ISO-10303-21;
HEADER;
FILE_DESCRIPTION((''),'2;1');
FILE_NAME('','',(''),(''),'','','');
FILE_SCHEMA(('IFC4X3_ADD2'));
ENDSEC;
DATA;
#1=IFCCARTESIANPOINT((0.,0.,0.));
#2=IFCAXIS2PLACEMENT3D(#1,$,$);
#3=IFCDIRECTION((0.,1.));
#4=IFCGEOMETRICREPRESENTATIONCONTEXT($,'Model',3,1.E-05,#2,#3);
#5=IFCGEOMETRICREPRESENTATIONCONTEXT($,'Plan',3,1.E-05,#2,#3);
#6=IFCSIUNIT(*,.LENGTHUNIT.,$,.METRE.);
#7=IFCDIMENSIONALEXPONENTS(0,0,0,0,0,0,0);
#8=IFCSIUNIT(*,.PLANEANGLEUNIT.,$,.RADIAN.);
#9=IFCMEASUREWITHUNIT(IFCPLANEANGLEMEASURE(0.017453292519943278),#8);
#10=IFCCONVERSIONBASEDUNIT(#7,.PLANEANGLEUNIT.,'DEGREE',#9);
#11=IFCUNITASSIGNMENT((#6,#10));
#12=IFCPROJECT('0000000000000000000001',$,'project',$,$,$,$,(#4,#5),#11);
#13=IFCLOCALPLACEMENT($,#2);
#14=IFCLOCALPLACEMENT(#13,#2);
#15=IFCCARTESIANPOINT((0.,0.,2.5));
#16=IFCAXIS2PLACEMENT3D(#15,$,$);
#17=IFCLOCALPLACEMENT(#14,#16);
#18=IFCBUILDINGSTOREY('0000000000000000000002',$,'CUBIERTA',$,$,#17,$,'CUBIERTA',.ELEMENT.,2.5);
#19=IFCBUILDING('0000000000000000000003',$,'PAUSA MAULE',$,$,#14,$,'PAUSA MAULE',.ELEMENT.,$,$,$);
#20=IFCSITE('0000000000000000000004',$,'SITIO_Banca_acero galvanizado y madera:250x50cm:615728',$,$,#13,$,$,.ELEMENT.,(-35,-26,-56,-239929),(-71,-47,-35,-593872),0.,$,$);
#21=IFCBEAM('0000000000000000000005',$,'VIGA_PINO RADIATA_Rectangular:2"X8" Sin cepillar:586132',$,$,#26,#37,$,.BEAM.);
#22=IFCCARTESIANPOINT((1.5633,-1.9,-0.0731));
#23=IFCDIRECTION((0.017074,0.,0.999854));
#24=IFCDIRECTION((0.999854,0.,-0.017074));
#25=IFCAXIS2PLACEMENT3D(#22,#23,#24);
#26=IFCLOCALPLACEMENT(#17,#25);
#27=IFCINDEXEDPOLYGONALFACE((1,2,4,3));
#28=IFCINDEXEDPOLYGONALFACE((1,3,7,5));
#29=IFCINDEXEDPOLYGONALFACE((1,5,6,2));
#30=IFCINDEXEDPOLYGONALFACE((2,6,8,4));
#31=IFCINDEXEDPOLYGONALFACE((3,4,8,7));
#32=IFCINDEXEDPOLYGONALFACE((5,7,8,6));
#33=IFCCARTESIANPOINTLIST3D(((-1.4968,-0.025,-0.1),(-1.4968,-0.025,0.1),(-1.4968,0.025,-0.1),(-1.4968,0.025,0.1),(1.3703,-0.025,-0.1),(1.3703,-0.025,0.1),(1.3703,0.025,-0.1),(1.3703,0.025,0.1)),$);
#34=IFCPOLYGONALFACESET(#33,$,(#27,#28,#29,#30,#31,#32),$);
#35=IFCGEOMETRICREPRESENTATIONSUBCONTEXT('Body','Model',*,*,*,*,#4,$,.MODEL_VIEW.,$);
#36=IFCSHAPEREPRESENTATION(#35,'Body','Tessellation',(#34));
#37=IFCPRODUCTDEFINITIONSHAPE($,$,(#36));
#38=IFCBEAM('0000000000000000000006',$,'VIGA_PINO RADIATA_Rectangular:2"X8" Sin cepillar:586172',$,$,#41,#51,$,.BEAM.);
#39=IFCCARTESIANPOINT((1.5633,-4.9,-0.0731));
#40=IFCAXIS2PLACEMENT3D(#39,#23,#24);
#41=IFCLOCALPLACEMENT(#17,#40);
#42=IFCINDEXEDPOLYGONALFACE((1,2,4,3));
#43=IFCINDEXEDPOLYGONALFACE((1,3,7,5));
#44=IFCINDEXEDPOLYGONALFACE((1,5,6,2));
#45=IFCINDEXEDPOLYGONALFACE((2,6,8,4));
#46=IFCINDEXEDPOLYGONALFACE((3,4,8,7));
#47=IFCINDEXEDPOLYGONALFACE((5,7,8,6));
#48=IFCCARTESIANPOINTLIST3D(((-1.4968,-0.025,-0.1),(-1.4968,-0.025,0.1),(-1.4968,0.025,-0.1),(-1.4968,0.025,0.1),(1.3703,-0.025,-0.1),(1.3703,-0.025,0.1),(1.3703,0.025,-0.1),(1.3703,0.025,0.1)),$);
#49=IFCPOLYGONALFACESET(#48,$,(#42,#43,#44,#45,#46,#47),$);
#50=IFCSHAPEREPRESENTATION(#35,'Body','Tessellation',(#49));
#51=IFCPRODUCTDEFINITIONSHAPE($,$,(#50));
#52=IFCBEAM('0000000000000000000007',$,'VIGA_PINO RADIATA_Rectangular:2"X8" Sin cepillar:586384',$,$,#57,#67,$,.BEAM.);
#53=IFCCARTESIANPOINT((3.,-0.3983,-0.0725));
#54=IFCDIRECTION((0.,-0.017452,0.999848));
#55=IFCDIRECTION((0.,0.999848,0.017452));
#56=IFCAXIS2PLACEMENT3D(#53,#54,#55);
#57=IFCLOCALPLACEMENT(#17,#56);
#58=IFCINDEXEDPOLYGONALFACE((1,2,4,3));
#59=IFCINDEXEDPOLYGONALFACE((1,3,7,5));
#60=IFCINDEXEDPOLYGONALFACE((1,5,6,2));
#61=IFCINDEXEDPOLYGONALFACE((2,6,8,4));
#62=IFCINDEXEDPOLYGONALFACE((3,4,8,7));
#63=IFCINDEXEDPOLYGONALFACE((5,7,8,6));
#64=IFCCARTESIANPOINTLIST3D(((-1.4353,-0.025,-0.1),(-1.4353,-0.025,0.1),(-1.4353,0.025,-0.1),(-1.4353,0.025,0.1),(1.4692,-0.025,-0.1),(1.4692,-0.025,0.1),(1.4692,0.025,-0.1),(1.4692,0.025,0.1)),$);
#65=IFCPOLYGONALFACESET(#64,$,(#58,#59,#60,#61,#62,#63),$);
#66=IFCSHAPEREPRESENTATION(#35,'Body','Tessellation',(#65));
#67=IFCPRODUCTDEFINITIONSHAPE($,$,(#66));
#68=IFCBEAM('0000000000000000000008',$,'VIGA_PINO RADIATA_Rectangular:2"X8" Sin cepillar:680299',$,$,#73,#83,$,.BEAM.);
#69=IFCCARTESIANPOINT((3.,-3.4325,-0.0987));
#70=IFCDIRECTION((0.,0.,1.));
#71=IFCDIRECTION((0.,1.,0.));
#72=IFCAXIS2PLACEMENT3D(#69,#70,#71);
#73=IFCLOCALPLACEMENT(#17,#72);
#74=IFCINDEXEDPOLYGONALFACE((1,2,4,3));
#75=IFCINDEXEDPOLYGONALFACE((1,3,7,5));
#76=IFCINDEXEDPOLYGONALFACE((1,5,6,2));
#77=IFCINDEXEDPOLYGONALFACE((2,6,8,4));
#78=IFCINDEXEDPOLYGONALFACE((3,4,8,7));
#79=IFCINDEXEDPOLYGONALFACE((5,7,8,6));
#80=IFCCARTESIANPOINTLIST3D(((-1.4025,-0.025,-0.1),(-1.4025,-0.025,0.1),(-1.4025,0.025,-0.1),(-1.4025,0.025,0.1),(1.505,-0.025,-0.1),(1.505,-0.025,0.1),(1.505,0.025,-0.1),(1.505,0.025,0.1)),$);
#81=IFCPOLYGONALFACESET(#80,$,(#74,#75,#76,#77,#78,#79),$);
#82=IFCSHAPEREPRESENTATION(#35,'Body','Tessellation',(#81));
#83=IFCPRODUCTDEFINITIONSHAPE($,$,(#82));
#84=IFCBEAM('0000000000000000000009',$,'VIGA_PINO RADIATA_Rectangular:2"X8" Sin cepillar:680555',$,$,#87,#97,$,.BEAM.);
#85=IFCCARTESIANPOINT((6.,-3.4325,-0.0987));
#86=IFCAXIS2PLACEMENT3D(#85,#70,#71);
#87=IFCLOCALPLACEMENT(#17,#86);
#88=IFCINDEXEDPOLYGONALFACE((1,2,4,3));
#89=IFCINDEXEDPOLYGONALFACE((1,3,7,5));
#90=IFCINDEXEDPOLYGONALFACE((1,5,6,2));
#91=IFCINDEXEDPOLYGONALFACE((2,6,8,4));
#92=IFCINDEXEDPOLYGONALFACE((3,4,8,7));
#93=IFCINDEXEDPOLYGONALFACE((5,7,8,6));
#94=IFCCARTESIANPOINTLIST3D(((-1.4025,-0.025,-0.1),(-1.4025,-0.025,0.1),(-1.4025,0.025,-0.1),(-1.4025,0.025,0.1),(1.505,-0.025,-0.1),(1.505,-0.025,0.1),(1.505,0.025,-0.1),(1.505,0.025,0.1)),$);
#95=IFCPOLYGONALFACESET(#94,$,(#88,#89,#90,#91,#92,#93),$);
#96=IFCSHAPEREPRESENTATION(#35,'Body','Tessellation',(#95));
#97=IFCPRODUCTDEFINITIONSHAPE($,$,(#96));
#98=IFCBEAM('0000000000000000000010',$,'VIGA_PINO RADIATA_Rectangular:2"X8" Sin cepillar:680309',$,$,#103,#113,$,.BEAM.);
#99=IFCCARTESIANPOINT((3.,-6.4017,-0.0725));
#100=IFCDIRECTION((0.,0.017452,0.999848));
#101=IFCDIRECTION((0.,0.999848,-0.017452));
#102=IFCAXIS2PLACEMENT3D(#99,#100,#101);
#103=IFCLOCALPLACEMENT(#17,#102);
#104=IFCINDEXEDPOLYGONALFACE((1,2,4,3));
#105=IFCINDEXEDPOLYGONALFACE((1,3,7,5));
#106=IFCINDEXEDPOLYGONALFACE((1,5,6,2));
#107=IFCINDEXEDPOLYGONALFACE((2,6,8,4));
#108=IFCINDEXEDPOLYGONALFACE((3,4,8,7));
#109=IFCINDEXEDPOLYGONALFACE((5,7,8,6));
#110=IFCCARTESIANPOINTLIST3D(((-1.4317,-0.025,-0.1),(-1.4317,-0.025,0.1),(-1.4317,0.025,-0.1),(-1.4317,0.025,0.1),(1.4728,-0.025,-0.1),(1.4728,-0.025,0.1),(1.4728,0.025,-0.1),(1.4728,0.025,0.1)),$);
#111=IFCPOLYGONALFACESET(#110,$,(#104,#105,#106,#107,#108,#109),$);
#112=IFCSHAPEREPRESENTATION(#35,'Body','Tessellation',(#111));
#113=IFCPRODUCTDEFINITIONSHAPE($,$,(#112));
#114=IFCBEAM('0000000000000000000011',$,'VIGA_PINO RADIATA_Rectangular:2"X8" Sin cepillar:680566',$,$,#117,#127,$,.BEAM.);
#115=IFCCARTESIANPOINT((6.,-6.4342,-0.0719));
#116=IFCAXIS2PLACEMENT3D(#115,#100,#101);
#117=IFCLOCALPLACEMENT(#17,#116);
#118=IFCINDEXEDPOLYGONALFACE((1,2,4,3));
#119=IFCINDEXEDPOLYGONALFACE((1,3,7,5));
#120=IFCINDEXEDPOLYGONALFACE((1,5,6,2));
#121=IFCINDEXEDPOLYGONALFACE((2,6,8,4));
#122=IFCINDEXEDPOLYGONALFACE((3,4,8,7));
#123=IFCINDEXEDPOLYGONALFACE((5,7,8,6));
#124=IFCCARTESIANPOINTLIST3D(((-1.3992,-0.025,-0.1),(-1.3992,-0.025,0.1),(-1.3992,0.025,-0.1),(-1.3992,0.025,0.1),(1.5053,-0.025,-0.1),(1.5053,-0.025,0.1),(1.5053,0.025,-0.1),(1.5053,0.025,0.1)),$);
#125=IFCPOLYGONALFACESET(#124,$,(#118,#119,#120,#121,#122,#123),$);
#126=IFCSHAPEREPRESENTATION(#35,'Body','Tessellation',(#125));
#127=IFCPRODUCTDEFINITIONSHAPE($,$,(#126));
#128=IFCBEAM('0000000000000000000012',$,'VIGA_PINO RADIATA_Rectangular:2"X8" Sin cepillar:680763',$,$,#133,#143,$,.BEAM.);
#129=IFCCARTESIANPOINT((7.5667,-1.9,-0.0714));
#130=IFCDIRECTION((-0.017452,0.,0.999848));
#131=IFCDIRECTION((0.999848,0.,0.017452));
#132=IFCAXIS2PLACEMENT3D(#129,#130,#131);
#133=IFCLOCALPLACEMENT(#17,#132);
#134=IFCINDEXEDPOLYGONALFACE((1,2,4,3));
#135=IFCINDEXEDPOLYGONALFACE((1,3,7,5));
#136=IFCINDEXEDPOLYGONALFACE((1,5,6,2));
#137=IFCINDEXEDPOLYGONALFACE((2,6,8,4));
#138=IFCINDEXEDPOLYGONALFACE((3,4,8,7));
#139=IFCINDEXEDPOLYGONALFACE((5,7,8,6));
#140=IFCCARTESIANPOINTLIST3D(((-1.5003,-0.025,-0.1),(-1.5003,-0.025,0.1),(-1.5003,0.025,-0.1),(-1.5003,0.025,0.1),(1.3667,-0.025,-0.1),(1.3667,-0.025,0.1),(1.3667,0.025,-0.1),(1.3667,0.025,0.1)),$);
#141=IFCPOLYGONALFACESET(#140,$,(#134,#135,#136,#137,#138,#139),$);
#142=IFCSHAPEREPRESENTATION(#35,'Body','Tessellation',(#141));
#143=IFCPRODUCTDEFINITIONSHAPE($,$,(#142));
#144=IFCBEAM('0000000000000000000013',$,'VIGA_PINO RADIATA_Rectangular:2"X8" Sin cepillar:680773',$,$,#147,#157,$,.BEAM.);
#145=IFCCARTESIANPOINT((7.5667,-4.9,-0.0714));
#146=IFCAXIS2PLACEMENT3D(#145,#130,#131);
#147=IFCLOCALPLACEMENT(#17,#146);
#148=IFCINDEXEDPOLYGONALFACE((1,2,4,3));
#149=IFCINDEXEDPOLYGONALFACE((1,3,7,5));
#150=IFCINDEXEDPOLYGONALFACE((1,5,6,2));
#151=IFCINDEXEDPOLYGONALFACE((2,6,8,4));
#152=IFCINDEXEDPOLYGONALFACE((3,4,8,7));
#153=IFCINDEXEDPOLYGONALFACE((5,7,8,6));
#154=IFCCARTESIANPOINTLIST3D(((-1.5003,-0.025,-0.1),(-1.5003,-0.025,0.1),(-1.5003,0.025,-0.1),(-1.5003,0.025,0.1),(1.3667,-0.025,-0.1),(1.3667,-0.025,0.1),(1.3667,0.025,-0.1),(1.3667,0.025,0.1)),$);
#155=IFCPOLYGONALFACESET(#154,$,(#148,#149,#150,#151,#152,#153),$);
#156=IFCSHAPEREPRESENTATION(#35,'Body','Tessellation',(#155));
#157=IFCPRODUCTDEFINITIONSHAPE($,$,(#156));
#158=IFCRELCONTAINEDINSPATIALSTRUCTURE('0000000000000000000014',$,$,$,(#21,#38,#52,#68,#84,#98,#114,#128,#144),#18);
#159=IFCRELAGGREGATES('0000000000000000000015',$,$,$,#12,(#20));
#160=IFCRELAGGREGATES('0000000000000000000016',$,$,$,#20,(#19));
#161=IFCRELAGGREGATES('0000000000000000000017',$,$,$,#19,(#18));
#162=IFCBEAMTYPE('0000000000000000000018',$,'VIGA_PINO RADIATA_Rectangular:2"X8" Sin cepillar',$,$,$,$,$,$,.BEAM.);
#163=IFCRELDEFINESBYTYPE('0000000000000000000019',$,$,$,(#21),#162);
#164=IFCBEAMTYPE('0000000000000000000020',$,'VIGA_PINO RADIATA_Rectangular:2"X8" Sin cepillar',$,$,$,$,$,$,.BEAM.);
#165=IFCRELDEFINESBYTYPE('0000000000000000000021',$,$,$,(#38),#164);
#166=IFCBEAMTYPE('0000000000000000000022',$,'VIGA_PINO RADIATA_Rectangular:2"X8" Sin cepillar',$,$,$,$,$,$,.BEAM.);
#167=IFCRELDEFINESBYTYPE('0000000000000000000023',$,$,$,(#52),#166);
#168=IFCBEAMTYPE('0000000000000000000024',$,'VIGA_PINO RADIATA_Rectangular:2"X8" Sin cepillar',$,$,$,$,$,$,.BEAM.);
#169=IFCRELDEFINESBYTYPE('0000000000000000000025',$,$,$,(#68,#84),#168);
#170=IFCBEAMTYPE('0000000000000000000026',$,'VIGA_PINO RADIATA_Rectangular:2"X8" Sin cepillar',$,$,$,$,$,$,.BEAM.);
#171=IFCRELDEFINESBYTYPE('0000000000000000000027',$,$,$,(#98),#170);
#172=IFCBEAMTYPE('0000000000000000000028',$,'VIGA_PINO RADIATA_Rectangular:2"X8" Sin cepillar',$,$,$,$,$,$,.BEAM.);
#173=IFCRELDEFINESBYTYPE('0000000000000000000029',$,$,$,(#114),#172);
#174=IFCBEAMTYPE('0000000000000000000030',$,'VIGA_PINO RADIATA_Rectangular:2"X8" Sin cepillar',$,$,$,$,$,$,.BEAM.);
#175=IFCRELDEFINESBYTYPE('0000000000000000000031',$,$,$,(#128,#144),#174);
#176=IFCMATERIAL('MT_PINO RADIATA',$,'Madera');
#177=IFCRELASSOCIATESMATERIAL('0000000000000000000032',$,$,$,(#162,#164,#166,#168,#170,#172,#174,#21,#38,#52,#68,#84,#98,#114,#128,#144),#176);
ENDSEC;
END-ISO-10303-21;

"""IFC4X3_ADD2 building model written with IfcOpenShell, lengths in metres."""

from ifc_helpers import new_model, entity, si_unit, converted_unit, direction, frame, origin, origin_2d_with_axis, place, context, subcontext, project, spatial, rectangle, extrude, source, transform, mapped, material, material_profile, profile_set, profile_usage, type_object, type_shapes, element, save


model = new_model("IFC4X3_ADD2")

# Units and contexts
model_context = context("Model", 3, precision=1e-05, world=origin(), true_north=direction((0.0, 1.0)))
plan_context = context("Plan", 3, precision=1e-05, world=origin(), true_north=direction((0.0, 1.0)))
body_context = subcontext(model_context, "Body", "Model", "MODEL_VIEW")
ifc_project = project(units=[si_unit("LENGTHUNIT", "METRE"), converted_unit("PLANEANGLEUNIT", "DEGREE", entity("IfcPlaneAngleMeasure", 0.017453292519943278), si_unit("PLANEANGLEUNIT", "RADIAN"), dimensions=[0, 0, 0, 0, 0, 0, 0])], contexts=[model_context, plan_context])

# Site, building, storey
site_placement = place(None, origin())
site = spatial("IfcSite", under=ifc_project, at=site_placement, Name="SITIO_Banca_acero galvanizado y madera:250x50cm:615728", CompositionType="ELEMENT", RefLatitude=(-35, -26, -56, -239929), RefLongitude=(-71, -47, -35, -593872), RefElevation=0.0)
building_placement = place(site_placement, origin())
building = spatial("IfcBuilding", under=site, at=building_placement, Name="PAUSA MAULE", LongName="PAUSA MAULE", CompositionType="ELEMENT")
storey_placement = place(building_placement, frame((0.0, 0.0, 2.5)))
storey = spatial("IfcBuildingStorey", under=building, at=storey_placement, Name="CUBIERTA", LongName="CUBIERTA", CompositionType="ELEMENT", Elevation=2.5)

# Beams
ifc_material_1 = material(Name="MT_PINO RADIATA", Category="Madera")
ifc_material_profile_1 = material_profile(ifc_material_1, rectangle(XDim=8.87, YDim=0.05, at=origin_2d_with_axis()), Name="2\"X8\" Sin cepillar")
ifc_profile_set_1 = profile_set([ifc_material_profile_1], Name="2\"X8\" Sin cepillar")
ifc_profile_usage_1 = profile_usage(ifc_profile_set_1, cardinal=8)
beam_type_1 = type_object("IfcBeamType", Name="VIGA_PINO RADIATA_Rectangular:2\"X8\" Sin cepillar", PredefinedType="BEAM", material=ifc_profile_set_1)
shared_shape_1 = source(origin(), body_context, "Body", "SweptSolid", [
    extrude(rectangle(XDim=2.8671, YDim=0.05, at=origin_2d_with_axis()), frame((-0.0633, 0.0, -0.1), z_axis=(0.0, 0.0, 1.0), x_axis=(-1.0, 0.0, 0.0)), (0.0, 0.0, 1.0), 0.2),
])
type_shapes(beam_type_1, [shared_shape_1])
beam_1_placement = place(storey_placement, frame((1.5633, -1.9, -0.0731), z_axis=(0.017074, 0.0, 0.999854), x_axis=(0.999854, 0.0, -0.017074)))
element("IfcBeam", 1, at=beam_1_placement, inside=storey, type_object=beam_type_1, material=ifc_profile_usage_1, Name="VIGA_PINO RADIATA_Rectangular:2\"X8\" Sin cepillar:586132", PredefinedType="BEAM", context=body_context, shape_type="MappedRepresentation", body=[
    mapped(shared_shape_1, transform((0.0, 0.0, 0.0), scale=1.0)),
])
beam_type_2 = type_object("IfcBeamType", Name="VIGA_PINO RADIATA_Rectangular:2\"X8\" Sin cepillar", PredefinedType="BEAM", material=ifc_profile_set_1)
shared_shape_2 = source(origin(), body_context, "Body", "SweptSolid", [
    extrude(rectangle(XDim=2.8671, YDim=0.05, at=origin_2d_with_axis()), frame((-0.0633, 0.0, -0.1), z_axis=(0.0, 0.0, 1.0), x_axis=(-1.0, 0.0, 0.0)), (0.0, 0.0, 1.0), 0.2),
])
type_shapes(beam_type_2, [shared_shape_2])
beam_2_placement = place(storey_placement, frame((1.5633, -4.9, -0.0731), z_axis=(0.017074, 0.0, 0.999854), x_axis=(0.999854, 0.0, -0.017074)))
element("IfcBeam", 2, at=beam_2_placement, inside=storey, type_object=beam_type_2, material=ifc_profile_usage_1, Name="VIGA_PINO RADIATA_Rectangular:2\"X8\" Sin cepillar:586172", PredefinedType="BEAM", context=body_context, shape_type="MappedRepresentation", body=[
    mapped(shared_shape_2, transform((0.0, 0.0, 0.0), scale=1.0)),
])
beam_type_3 = type_object("IfcBeamType", Name="VIGA_PINO RADIATA_Rectangular:2\"X8\" Sin cepillar", PredefinedType="BEAM", material=ifc_profile_set_1)
shared_shape_3 = source(origin(), body_context, "Body", "SweptSolid", [
    extrude(rectangle(XDim=2.9045, YDim=0.05, at=origin_2d_with_axis()), frame((0.017, 0.0, -0.1), z_axis=(0.0, 0.0, 1.0), x_axis=(-1.0, 0.0, 0.0)), (0.0, 0.0, 1.0), 0.2),
])
type_shapes(beam_type_3, [shared_shape_3])
beam_3_placement = place(storey_placement, frame((3.0, -0.3983, -0.0725), z_axis=(0.0, -0.017452, 0.999848), x_axis=(0.0, 0.999848, 0.017452)))
element("IfcBeam", 3, at=beam_3_placement, inside=storey, type_object=beam_type_3, material=ifc_profile_usage_1, Name="VIGA_PINO RADIATA_Rectangular:2\"X8\" Sin cepillar:586384", PredefinedType="BEAM", context=body_context, shape_type="MappedRepresentation", body=[
    mapped(shared_shape_3, transform((0.0, 0.0, 0.0), scale=1.0)),
])

# Beams
beam_type_4 = type_object("IfcBeamType", Name="VIGA_PINO RADIATA_Rectangular:2\"X8\" Sin cepillar", PredefinedType="BEAM", material=ifc_profile_set_1)
shared_shape_4 = source(origin(), body_context, "Body", "SweptSolid", [
    extrude(rectangle(XDim=2.9075, YDim=0.05, at=origin_2d_with_axis()), frame((0.0512, 0.0, -0.1), z_axis=(0.0, 0.0, 1.0), x_axis=(-1.0, 0.0, 0.0)), (0.0, 0.0, 1.0), 0.2),
])
type_shapes(beam_type_4, [shared_shape_4])
for number, where, z_axis, x_axis, name in (
    (4, (3.0, -3.4325, -0.0987), (0.0, 0.0, 1.0), (0.0, 1.0, 0.0), "VIGA_PINO RADIATA_Rectangular:2\"X8\" Sin cepillar:680299"),
    (5, (6.0, -3.4325, -0.0987), (0.0, 0.0, 1.0), (0.0, 1.0, 0.0), "VIGA_PINO RADIATA_Rectangular:2\"X8\" Sin cepillar:680555"),
):
    element("IfcBeam", number, at=place(storey_placement, frame(where, z_axis=z_axis, x_axis=x_axis)), inside=storey, type_object=beam_type_4, material=ifc_profile_usage_1, Name=name, PredefinedType="BEAM", context=body_context, shape_type="MappedRepresentation", body=[
        mapped(shared_shape_4, transform((0.0, 0.0, 0.0), scale=1.0)),
    ])
beam_type_5 = type_object("IfcBeamType", Name="VIGA_PINO RADIATA_Rectangular:2\"X8\" Sin cepillar", PredefinedType="BEAM", material=ifc_profile_set_1)
shared_shape_5 = source(origin(), body_context, "Body", "SweptSolid", [
    extrude(rectangle(XDim=2.9045, YDim=0.05, at=origin_2d_with_axis()), frame((0.0205, 0.0, -0.1), z_axis=(0.0, 0.0, 1.0), x_axis=(-1.0, 0.0, 0.0)), (0.0, 0.0, 1.0), 0.2),
])
type_shapes(beam_type_5, [shared_shape_5])
beam_4_placement = place(storey_placement, frame((3.0, -6.4017, -0.0725), z_axis=(0.0, 0.017452, 0.999848), x_axis=(0.0, 0.999848, -0.017452)))
element("IfcBeam", 6, at=beam_4_placement, inside=storey, type_object=beam_type_5, material=ifc_profile_usage_1, Name="VIGA_PINO RADIATA_Rectangular:2\"X8\" Sin cepillar:680309", PredefinedType="BEAM", context=body_context, shape_type="MappedRepresentation", body=[
    mapped(shared_shape_5, transform((0.0, 0.0, 0.0), scale=1.0)),
])
beam_type_6 = type_object("IfcBeamType", Name="VIGA_PINO RADIATA_Rectangular:2\"X8\" Sin cepillar", PredefinedType="BEAM", material=ifc_profile_set_1)
shared_shape_6 = source(origin(), body_context, "Body", "SweptSolid", [
    extrude(rectangle(XDim=2.9045, YDim=0.05, at=origin_2d_with_axis()), frame((0.053, 0.0, -0.1), z_axis=(0.0, 0.0, 1.0), x_axis=(-1.0, 0.0, 0.0)), (0.0, 0.0, 1.0), 0.2),
])
type_shapes(beam_type_6, [shared_shape_6])
beam_5_placement = place(storey_placement, frame((6.0, -6.4342, -0.0719), z_axis=(0.0, 0.017452, 0.999848), x_axis=(0.0, 0.999848, -0.017452)))
element("IfcBeam", 7, at=beam_5_placement, inside=storey, type_object=beam_type_6, material=ifc_profile_usage_1, Name="VIGA_PINO RADIATA_Rectangular:2\"X8\" Sin cepillar:680566", PredefinedType="BEAM", context=body_context, shape_type="MappedRepresentation", body=[
    mapped(shared_shape_6, transform((0.0, 0.0, 0.0), scale=1.0)),
])
beam_type_7 = type_object("IfcBeamType", Name="VIGA_PINO RADIATA_Rectangular:2\"X8\" Sin cepillar", PredefinedType="BEAM", material=ifc_profile_set_1)
shared_shape_7 = source(origin(), body_context, "Body", "SweptSolid", [
    extrude(rectangle(XDim=2.867, YDim=0.05, at=origin_2d_with_axis()), frame((-0.0668, 0.0, -0.1), z_axis=(0.0, 0.0, 1.0), x_axis=(-1.0, 0.0, 0.0)), (0.0, 0.0, 1.0), 0.2),
])
type_shapes(beam_type_7, [shared_shape_7])
for number, where, z_axis, x_axis, name in (
    (8, (7.5667, -1.9, -0.0714), (-0.017452, 0.0, 0.999848), (0.999848, 0.0, 0.017452), "VIGA_PINO RADIATA_Rectangular:2\"X8\" Sin cepillar:680763"),
    (9, (7.5667, -4.9, -0.0714), (-0.017452, 0.0, 0.999848), (0.999848, 0.0, 0.017452), "VIGA_PINO RADIATA_Rectangular:2\"X8\" Sin cepillar:680773"),
):
    element("IfcBeam", number, at=place(storey_placement, frame(where, z_axis=z_axis, x_axis=x_axis)), inside=storey, type_object=beam_type_7, material=ifc_profile_usage_1, Name=name, PredefinedType="BEAM", context=body_context, shape_type="MappedRepresentation", body=[
        mapped(shared_shape_7, transform((0.0, 0.0, 0.0), scale=1.0)),
    ])

save(model, "model.ifc")
